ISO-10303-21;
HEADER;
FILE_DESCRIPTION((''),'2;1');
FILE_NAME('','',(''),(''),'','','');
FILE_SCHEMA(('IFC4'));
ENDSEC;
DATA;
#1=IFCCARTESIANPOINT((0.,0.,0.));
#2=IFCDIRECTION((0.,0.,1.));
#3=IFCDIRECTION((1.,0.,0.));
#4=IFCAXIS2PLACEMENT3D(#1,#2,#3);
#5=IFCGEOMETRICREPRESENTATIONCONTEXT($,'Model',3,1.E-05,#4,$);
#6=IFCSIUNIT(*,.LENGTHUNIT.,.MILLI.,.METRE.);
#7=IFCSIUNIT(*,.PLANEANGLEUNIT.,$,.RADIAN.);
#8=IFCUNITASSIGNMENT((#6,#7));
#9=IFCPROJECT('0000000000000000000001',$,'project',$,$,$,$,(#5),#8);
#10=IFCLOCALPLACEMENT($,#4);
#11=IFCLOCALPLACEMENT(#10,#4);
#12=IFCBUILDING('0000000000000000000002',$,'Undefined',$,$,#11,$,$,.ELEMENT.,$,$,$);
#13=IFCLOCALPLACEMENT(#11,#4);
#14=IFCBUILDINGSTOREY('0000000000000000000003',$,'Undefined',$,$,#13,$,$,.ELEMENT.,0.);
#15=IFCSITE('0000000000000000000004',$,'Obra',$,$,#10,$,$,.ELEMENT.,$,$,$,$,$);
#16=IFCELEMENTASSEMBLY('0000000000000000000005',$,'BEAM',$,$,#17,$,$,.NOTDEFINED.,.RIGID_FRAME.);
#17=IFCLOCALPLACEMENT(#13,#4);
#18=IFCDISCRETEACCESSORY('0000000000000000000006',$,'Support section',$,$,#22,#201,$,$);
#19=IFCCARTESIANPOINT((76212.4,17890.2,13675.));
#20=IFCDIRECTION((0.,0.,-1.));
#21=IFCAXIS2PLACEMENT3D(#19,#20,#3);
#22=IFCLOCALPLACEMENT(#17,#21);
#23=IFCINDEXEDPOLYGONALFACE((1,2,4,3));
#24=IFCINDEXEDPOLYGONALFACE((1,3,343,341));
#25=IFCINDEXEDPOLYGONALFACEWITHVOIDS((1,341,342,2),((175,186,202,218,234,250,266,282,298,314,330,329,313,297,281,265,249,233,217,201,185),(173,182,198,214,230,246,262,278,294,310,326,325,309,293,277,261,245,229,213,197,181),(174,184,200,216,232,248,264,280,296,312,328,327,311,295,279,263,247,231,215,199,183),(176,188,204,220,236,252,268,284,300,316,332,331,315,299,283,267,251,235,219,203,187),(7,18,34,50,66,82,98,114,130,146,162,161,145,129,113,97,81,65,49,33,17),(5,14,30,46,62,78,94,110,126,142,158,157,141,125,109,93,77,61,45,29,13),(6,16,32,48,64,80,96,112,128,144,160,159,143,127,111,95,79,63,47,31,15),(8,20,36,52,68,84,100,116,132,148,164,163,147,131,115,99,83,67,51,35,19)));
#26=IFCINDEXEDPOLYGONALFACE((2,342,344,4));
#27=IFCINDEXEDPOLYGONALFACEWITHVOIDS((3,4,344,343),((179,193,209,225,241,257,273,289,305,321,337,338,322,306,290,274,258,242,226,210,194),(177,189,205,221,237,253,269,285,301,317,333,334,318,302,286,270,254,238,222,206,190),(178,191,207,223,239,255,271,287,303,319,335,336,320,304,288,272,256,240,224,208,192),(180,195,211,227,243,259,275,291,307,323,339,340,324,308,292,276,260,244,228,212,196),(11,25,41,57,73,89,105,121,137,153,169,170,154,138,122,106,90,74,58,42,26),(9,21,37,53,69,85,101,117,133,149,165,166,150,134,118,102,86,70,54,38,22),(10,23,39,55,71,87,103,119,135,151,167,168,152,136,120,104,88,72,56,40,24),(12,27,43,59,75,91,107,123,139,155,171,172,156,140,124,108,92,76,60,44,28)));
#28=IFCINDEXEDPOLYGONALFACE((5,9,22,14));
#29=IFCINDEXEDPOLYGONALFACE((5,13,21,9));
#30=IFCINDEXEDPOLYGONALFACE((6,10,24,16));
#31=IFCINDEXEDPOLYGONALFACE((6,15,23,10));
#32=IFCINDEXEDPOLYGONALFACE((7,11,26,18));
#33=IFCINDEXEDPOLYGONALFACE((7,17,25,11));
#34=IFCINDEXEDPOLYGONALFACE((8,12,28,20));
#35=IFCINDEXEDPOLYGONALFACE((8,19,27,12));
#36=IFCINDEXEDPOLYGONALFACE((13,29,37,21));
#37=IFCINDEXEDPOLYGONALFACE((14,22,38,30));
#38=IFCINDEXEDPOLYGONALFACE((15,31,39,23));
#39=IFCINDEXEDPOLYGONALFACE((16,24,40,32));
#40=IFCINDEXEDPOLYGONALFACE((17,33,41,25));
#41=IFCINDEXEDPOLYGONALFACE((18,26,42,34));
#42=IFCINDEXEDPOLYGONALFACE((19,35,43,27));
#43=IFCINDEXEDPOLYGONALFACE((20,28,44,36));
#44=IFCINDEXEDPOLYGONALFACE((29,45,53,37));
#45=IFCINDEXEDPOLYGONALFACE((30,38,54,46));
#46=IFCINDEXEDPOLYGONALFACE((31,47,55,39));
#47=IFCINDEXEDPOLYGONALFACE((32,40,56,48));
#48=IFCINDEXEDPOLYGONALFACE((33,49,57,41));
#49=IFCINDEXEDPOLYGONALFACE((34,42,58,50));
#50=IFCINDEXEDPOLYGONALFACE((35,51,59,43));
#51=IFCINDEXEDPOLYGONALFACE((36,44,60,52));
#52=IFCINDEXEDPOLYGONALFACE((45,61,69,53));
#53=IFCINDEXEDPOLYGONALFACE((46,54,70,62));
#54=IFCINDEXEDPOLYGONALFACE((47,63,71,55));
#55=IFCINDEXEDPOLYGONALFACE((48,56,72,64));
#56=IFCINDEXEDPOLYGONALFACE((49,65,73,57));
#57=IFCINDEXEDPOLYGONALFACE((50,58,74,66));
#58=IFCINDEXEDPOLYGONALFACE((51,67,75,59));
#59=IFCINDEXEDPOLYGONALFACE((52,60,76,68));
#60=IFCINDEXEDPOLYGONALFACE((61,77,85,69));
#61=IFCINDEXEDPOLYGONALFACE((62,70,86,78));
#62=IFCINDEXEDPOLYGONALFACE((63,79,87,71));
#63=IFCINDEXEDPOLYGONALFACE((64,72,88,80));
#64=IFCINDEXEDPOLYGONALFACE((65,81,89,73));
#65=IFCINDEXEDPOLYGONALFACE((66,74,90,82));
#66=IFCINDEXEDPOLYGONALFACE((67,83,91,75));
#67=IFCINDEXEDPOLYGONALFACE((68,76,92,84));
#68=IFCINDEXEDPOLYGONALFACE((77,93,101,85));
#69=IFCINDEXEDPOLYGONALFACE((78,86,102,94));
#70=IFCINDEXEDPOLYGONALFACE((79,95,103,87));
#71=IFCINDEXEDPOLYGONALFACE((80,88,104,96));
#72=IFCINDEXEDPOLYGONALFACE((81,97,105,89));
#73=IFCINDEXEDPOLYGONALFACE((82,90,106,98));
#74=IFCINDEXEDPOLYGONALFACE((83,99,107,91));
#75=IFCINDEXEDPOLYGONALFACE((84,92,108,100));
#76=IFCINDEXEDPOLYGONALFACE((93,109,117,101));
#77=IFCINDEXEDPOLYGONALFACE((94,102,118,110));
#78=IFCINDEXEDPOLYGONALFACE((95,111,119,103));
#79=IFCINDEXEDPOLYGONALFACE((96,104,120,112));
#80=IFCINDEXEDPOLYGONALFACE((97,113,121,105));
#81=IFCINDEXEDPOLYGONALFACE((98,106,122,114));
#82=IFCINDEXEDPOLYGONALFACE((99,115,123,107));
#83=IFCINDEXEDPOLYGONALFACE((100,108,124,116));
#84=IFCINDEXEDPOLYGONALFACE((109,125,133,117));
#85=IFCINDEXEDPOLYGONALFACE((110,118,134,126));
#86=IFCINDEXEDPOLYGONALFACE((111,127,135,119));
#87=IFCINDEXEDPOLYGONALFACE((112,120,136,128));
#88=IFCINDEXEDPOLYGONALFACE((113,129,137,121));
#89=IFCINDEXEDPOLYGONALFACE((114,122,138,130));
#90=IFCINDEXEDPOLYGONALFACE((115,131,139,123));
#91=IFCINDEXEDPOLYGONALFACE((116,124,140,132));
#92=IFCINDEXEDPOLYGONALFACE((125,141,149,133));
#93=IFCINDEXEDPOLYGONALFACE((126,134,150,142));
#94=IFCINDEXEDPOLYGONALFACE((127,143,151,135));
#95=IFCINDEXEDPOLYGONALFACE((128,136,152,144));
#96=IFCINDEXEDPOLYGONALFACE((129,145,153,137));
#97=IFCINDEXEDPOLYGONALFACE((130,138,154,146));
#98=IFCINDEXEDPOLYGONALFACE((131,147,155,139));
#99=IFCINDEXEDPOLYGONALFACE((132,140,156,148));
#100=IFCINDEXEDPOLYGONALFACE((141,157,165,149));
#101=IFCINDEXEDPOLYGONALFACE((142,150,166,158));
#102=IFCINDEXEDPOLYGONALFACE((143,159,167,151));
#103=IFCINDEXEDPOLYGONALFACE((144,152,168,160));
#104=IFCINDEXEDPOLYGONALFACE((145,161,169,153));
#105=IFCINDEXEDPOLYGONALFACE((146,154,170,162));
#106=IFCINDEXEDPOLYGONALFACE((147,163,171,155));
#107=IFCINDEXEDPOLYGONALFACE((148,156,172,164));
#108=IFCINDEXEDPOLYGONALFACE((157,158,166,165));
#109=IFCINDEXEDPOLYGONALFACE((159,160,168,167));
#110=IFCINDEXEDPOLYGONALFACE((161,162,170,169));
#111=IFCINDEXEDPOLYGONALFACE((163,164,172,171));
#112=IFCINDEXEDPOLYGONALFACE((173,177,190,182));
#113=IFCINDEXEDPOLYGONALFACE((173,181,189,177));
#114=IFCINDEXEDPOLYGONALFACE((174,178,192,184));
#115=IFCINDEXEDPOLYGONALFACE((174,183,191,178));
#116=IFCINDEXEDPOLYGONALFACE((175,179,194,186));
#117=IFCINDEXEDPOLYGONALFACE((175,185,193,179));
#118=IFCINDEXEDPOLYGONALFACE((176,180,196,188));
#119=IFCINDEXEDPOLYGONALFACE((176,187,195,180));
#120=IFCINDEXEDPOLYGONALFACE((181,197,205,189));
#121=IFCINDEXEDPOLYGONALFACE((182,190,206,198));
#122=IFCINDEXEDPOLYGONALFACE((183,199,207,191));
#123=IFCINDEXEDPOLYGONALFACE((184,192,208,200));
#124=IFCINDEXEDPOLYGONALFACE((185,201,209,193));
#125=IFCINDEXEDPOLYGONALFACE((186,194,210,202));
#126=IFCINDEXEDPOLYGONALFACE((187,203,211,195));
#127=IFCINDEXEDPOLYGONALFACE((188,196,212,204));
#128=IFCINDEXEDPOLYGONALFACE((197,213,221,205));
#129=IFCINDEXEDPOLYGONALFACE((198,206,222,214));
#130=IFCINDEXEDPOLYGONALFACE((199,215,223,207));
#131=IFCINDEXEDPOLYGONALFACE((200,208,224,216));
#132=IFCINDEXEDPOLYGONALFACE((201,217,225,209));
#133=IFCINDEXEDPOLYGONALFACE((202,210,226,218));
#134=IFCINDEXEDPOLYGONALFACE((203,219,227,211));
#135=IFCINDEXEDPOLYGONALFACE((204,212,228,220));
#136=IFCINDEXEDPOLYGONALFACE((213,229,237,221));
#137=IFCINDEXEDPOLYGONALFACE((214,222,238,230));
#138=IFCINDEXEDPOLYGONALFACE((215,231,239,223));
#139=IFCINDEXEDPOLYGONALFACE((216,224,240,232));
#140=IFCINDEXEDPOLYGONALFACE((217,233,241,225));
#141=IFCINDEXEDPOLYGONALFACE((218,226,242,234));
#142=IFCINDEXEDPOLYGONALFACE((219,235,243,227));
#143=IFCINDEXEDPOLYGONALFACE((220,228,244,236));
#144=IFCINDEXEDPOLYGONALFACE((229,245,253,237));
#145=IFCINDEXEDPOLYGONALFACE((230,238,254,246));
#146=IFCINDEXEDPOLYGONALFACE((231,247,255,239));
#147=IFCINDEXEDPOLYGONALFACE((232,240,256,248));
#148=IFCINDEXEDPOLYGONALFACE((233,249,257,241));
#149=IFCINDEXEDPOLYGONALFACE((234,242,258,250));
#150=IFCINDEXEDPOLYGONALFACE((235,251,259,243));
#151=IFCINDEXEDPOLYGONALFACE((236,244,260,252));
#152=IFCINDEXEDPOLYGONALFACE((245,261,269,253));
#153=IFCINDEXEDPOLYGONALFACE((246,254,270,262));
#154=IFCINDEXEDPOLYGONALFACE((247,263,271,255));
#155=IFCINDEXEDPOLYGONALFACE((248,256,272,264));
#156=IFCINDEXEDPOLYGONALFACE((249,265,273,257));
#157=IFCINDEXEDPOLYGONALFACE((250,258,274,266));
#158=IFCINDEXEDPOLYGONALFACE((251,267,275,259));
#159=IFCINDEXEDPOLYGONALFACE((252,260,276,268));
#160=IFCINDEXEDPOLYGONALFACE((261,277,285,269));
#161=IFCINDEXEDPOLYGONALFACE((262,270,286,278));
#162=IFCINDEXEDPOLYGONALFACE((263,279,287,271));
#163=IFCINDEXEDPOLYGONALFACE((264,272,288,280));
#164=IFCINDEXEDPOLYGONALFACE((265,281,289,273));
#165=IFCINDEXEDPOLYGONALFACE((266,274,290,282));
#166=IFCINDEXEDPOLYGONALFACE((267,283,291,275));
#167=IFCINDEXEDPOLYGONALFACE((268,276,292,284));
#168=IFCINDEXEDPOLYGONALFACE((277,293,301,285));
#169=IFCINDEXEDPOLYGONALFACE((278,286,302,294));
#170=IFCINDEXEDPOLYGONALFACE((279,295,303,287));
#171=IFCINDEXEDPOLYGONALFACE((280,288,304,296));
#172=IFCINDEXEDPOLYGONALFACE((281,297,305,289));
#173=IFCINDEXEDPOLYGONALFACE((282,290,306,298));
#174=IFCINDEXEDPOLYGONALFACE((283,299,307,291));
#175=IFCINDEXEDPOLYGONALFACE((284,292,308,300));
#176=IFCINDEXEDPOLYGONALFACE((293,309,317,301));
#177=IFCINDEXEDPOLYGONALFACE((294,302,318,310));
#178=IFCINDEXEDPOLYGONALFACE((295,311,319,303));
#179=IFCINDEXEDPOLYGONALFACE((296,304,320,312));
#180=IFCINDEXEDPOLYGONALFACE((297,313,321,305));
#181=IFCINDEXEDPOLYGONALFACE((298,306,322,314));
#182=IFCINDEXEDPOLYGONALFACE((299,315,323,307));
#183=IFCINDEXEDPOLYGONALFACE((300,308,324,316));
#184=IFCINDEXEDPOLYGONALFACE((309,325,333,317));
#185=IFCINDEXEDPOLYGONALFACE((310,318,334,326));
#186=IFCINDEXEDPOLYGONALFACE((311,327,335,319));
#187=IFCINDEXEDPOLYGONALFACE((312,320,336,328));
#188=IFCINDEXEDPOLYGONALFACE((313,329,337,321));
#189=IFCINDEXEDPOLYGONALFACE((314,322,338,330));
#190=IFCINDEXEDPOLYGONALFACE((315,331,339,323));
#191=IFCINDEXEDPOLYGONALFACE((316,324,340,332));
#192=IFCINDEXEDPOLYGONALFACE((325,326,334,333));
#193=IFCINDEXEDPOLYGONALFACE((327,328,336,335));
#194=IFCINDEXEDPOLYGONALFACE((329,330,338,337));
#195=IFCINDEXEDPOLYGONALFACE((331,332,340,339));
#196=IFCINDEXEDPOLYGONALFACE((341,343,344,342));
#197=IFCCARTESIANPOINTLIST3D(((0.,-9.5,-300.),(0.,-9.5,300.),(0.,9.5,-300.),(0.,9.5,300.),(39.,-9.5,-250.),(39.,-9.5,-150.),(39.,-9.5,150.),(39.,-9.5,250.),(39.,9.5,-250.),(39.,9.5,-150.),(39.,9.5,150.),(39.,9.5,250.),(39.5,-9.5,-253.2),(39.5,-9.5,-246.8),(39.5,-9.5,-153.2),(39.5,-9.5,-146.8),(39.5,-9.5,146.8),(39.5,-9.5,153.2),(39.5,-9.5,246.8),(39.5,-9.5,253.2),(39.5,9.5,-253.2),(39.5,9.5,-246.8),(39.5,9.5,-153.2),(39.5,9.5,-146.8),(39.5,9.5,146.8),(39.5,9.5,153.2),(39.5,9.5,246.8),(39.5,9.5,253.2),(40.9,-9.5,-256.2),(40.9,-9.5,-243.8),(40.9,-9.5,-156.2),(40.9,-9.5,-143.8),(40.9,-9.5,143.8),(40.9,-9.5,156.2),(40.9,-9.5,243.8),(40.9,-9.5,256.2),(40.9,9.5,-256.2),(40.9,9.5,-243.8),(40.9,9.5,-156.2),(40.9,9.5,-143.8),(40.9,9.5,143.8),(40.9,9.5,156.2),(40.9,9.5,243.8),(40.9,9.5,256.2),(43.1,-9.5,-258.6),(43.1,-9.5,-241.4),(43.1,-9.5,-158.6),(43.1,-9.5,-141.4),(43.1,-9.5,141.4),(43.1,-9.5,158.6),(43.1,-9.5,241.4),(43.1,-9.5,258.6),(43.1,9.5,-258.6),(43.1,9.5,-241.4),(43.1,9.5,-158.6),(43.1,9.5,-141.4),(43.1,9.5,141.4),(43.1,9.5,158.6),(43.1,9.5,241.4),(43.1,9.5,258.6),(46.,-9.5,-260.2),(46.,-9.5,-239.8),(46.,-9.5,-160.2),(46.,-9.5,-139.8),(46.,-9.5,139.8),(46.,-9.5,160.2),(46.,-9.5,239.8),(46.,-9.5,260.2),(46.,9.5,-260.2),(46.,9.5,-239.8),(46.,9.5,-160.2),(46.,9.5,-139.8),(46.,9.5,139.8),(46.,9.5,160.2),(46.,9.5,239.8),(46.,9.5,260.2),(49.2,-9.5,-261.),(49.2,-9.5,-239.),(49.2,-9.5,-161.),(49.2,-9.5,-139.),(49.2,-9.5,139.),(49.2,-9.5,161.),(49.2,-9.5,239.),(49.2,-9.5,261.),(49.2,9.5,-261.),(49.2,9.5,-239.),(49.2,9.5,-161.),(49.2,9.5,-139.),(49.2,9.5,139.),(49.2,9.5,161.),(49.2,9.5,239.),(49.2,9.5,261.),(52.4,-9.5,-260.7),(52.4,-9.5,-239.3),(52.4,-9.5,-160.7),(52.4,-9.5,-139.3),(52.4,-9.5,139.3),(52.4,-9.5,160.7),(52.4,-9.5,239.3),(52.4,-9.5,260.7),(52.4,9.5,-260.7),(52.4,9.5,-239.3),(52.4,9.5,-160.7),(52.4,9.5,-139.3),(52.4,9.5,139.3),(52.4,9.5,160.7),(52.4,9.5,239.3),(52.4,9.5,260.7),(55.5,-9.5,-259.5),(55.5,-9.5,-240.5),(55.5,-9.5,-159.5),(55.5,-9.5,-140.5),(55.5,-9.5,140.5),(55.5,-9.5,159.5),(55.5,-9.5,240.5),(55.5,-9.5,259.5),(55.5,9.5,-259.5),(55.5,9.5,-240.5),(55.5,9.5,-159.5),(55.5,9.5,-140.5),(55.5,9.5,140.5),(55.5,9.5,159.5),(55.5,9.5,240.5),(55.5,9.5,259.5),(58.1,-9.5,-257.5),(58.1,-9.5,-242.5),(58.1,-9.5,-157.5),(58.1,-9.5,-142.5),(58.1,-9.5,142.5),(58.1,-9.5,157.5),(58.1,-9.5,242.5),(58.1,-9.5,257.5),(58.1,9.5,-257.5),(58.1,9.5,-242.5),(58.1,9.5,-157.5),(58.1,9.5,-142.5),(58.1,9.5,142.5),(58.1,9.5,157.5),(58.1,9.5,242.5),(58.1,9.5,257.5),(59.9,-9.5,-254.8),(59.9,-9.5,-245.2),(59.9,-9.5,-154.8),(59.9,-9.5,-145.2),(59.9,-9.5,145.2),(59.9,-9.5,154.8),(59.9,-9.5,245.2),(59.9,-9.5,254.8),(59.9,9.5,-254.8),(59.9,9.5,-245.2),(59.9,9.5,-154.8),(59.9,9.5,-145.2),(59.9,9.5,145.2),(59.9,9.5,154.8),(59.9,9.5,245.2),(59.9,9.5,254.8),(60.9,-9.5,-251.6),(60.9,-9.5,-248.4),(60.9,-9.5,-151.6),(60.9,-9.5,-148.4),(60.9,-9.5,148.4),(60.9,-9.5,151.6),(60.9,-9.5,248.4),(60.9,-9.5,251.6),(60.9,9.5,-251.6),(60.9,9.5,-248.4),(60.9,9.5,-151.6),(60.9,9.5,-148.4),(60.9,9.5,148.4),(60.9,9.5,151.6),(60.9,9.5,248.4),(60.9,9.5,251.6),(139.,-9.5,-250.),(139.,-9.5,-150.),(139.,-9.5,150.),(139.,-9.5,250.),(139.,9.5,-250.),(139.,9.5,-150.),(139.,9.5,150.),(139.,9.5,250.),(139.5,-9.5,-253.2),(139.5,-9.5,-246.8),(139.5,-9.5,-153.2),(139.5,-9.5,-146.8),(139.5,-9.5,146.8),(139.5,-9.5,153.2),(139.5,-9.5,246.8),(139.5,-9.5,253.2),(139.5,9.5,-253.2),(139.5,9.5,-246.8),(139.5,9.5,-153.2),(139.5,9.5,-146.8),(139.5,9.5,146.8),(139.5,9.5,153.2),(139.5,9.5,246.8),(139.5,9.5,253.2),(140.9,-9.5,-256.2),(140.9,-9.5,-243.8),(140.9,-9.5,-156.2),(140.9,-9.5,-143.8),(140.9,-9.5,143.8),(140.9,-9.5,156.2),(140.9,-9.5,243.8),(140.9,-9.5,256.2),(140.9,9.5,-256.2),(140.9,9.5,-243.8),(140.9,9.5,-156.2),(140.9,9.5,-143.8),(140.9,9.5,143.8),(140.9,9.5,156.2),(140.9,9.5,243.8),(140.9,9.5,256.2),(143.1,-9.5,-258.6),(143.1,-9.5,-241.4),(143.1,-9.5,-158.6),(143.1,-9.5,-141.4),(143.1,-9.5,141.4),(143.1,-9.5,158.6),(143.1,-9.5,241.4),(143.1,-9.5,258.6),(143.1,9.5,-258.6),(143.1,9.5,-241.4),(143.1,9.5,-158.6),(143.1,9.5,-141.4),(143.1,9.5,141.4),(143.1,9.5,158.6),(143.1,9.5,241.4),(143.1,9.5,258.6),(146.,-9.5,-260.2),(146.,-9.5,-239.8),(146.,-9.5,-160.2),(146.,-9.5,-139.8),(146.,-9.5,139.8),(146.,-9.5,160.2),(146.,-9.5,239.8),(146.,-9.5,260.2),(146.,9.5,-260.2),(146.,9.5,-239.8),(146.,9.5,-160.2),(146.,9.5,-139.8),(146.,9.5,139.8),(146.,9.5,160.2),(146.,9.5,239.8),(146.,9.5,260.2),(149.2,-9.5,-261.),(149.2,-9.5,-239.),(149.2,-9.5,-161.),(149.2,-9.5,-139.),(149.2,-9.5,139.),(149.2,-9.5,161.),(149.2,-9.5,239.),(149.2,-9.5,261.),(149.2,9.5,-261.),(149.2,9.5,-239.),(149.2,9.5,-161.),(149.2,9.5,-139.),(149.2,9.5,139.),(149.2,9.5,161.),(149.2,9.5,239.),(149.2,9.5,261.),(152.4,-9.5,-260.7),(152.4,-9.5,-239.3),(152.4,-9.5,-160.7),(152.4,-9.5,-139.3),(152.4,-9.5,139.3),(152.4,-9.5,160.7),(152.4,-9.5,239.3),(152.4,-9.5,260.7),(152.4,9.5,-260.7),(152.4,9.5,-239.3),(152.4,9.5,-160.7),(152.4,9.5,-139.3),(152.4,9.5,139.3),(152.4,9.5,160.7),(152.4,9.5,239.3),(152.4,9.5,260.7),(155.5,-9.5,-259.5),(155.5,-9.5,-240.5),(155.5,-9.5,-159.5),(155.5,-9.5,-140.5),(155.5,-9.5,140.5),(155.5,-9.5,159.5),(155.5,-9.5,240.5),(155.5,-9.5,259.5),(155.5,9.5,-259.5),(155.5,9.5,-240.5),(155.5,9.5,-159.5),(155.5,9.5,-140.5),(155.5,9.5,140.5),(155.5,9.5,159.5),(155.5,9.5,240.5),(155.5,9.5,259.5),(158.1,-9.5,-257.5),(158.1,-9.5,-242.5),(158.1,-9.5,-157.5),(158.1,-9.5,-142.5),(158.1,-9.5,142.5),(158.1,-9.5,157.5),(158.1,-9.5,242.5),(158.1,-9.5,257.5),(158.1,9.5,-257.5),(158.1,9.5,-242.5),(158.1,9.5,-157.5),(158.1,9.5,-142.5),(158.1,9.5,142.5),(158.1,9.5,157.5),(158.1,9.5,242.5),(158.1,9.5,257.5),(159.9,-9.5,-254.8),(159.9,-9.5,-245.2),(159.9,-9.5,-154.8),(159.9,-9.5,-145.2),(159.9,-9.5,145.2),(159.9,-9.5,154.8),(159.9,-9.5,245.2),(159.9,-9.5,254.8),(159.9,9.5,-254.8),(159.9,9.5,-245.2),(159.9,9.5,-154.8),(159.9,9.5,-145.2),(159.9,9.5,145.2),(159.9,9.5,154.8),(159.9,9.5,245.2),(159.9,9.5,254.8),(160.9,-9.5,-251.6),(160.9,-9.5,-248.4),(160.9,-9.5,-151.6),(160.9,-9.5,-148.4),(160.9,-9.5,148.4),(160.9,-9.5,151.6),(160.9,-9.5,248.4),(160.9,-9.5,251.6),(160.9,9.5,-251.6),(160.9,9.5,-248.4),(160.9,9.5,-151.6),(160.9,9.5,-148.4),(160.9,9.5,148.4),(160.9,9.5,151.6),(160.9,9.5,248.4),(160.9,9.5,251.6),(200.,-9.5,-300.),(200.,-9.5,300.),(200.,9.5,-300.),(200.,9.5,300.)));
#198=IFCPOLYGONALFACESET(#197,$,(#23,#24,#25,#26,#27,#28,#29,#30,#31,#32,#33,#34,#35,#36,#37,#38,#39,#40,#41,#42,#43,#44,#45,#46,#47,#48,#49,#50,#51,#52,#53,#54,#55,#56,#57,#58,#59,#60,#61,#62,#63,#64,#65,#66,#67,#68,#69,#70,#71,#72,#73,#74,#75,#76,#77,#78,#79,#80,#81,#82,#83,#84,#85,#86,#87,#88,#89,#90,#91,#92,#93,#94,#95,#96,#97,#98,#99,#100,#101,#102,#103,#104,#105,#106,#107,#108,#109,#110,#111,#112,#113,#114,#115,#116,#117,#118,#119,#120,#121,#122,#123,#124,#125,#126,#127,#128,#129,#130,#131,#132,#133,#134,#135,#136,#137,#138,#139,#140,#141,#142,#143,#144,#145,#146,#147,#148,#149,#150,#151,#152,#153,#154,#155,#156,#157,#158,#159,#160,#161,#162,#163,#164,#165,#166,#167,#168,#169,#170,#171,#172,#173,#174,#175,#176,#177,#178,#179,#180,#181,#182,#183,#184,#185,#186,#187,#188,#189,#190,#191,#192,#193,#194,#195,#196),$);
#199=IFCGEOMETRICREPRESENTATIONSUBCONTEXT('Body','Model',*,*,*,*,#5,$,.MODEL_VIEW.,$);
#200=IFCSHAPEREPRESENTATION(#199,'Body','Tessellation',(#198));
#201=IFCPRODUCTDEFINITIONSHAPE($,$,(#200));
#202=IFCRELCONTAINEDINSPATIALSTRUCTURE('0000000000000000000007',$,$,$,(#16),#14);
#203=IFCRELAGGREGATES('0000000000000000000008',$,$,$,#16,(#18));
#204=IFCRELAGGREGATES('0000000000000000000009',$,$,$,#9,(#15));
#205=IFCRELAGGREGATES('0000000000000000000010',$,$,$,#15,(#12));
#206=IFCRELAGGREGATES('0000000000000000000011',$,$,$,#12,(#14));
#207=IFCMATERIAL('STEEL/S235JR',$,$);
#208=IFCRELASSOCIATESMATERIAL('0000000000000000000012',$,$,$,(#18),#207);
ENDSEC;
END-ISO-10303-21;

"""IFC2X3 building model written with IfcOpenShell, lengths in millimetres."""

from ifc_helpers import new_model, si_unit, frame, origin_with_axes, origin_2d_with_axis, place, context, subcontext, project, spatial, rectangle, circle, extrude, source, transform, mapped, material, element, aggregate, save


model = new_model("IFC2X3")

# Units and contexts
model_context = context("Model", 3, precision=1e-05, world=origin_with_axes())
body_context = subcontext(model_context, "Body", "Model", "MODEL_VIEW")
ifc_project = project(units=[si_unit("LENGTHUNIT", "METRE", prefix="MILLI"), si_unit("PLANEANGLEUNIT", "RADIAN")], contexts=[model_context])

# Site, building, storey
site_placement = place(None, origin_with_axes())
site = spatial("IfcSite", under=ifc_project, at=site_placement, Name="Obra", CompositionType="ELEMENT")
building_placement = place(site_placement, origin_with_axes())
building = spatial("IfcBuilding", under=site, at=building_placement, Name="Undefined", CompositionType="ELEMENT")
storey_placement = place(building_placement, origin_with_axes())
storey = spatial("IfcBuildingStorey", under=building, at=storey_placement, Name="Undefined", CompositionType="ELEMENT", Elevation=0.0)

# Shared definitions
ifc_material_1 = material(Name="STEEL/S235JR")

# Element assembly, discrete accessory, opening
assembly_1_placement = place(storey_placement, origin_with_axes())
assembly_1 = element("IfcElementAssembly", 1, at=assembly_1_placement, inside=storey, Name="BEAM", AssemblyPlace="NOTDEFINED", PredefinedType="RIGID_FRAME")
discrete_accessory_1_placement = place(assembly_1_placement, frame((76212.4, 17890.2, 13675.0), z_axis=(0.0, 0.0, -1.0), x_axis=(1.0, 0.0, 0.0)))
discrete_accessory_1 = element("IfcDiscreteAccessory", 2, at=discrete_accessory_1_placement, material=ifc_material_1, Name="Support section", context=body_context, shape_type="SweptSolid", body=[
    extrude(rectangle(XDim=19.0, YDim=600.0, at=origin_2d_with_axis()), frame((200.0, 0.0, 0.0), z_axis=(-1.0, 0.0, 0.0), x_axis=(0.0, -1.0, 0.0)), (0.0, 0.0, 1.0), 200.0),
])
shared_shape_1 = source(origin_with_axes(), body_context, "Body", "SweptSolid", [
    extrude(circle(Radius=11.0, at=origin_2d_with_axis()), frame((0.0, -0.1, 0.0), z_axis=(0.0, 1.0, 0.0), x_axis=(1.0, 0.0, 0.0)), (0.0, 0.0, 1.0), 19.2),
])
opening_1_placement = place(assembly_1_placement, frame((76407.5, 17880.7, 13675.0), z_axis=(0.0, 0.0, -1.0), x_axis=(-1.0, 0.0, 0.0)))
element("IfcOpeningElement", 3, at=opening_1_placement, cuts=discrete_accessory_1, ObjectType="Opening", context=body_context, shape_type="MappedRepresentation", body=[
    mapped(shared_shape_1, transform((45.1, 0.0, -250.0))),
    mapped(shared_shape_1, transform((45.1, 0.0, -150.0))),
    mapped(shared_shape_1, transform((45.1, 0.0, 150.0))),
    mapped(shared_shape_1, transform((45.1, 0.0, 250.0))),
    mapped(shared_shape_1, transform((145.1, 0.0, -250.0))),
    mapped(shared_shape_1, transform((145.1, 0.0, -150.0))),
    mapped(shared_shape_1, transform((145.1, 0.0, 150.0))),
    mapped(shared_shape_1, transform((145.1, 0.0, 250.0))),
])
aggregate(assembly_1, [discrete_accessory_1])

save(model, "model.ifc")
